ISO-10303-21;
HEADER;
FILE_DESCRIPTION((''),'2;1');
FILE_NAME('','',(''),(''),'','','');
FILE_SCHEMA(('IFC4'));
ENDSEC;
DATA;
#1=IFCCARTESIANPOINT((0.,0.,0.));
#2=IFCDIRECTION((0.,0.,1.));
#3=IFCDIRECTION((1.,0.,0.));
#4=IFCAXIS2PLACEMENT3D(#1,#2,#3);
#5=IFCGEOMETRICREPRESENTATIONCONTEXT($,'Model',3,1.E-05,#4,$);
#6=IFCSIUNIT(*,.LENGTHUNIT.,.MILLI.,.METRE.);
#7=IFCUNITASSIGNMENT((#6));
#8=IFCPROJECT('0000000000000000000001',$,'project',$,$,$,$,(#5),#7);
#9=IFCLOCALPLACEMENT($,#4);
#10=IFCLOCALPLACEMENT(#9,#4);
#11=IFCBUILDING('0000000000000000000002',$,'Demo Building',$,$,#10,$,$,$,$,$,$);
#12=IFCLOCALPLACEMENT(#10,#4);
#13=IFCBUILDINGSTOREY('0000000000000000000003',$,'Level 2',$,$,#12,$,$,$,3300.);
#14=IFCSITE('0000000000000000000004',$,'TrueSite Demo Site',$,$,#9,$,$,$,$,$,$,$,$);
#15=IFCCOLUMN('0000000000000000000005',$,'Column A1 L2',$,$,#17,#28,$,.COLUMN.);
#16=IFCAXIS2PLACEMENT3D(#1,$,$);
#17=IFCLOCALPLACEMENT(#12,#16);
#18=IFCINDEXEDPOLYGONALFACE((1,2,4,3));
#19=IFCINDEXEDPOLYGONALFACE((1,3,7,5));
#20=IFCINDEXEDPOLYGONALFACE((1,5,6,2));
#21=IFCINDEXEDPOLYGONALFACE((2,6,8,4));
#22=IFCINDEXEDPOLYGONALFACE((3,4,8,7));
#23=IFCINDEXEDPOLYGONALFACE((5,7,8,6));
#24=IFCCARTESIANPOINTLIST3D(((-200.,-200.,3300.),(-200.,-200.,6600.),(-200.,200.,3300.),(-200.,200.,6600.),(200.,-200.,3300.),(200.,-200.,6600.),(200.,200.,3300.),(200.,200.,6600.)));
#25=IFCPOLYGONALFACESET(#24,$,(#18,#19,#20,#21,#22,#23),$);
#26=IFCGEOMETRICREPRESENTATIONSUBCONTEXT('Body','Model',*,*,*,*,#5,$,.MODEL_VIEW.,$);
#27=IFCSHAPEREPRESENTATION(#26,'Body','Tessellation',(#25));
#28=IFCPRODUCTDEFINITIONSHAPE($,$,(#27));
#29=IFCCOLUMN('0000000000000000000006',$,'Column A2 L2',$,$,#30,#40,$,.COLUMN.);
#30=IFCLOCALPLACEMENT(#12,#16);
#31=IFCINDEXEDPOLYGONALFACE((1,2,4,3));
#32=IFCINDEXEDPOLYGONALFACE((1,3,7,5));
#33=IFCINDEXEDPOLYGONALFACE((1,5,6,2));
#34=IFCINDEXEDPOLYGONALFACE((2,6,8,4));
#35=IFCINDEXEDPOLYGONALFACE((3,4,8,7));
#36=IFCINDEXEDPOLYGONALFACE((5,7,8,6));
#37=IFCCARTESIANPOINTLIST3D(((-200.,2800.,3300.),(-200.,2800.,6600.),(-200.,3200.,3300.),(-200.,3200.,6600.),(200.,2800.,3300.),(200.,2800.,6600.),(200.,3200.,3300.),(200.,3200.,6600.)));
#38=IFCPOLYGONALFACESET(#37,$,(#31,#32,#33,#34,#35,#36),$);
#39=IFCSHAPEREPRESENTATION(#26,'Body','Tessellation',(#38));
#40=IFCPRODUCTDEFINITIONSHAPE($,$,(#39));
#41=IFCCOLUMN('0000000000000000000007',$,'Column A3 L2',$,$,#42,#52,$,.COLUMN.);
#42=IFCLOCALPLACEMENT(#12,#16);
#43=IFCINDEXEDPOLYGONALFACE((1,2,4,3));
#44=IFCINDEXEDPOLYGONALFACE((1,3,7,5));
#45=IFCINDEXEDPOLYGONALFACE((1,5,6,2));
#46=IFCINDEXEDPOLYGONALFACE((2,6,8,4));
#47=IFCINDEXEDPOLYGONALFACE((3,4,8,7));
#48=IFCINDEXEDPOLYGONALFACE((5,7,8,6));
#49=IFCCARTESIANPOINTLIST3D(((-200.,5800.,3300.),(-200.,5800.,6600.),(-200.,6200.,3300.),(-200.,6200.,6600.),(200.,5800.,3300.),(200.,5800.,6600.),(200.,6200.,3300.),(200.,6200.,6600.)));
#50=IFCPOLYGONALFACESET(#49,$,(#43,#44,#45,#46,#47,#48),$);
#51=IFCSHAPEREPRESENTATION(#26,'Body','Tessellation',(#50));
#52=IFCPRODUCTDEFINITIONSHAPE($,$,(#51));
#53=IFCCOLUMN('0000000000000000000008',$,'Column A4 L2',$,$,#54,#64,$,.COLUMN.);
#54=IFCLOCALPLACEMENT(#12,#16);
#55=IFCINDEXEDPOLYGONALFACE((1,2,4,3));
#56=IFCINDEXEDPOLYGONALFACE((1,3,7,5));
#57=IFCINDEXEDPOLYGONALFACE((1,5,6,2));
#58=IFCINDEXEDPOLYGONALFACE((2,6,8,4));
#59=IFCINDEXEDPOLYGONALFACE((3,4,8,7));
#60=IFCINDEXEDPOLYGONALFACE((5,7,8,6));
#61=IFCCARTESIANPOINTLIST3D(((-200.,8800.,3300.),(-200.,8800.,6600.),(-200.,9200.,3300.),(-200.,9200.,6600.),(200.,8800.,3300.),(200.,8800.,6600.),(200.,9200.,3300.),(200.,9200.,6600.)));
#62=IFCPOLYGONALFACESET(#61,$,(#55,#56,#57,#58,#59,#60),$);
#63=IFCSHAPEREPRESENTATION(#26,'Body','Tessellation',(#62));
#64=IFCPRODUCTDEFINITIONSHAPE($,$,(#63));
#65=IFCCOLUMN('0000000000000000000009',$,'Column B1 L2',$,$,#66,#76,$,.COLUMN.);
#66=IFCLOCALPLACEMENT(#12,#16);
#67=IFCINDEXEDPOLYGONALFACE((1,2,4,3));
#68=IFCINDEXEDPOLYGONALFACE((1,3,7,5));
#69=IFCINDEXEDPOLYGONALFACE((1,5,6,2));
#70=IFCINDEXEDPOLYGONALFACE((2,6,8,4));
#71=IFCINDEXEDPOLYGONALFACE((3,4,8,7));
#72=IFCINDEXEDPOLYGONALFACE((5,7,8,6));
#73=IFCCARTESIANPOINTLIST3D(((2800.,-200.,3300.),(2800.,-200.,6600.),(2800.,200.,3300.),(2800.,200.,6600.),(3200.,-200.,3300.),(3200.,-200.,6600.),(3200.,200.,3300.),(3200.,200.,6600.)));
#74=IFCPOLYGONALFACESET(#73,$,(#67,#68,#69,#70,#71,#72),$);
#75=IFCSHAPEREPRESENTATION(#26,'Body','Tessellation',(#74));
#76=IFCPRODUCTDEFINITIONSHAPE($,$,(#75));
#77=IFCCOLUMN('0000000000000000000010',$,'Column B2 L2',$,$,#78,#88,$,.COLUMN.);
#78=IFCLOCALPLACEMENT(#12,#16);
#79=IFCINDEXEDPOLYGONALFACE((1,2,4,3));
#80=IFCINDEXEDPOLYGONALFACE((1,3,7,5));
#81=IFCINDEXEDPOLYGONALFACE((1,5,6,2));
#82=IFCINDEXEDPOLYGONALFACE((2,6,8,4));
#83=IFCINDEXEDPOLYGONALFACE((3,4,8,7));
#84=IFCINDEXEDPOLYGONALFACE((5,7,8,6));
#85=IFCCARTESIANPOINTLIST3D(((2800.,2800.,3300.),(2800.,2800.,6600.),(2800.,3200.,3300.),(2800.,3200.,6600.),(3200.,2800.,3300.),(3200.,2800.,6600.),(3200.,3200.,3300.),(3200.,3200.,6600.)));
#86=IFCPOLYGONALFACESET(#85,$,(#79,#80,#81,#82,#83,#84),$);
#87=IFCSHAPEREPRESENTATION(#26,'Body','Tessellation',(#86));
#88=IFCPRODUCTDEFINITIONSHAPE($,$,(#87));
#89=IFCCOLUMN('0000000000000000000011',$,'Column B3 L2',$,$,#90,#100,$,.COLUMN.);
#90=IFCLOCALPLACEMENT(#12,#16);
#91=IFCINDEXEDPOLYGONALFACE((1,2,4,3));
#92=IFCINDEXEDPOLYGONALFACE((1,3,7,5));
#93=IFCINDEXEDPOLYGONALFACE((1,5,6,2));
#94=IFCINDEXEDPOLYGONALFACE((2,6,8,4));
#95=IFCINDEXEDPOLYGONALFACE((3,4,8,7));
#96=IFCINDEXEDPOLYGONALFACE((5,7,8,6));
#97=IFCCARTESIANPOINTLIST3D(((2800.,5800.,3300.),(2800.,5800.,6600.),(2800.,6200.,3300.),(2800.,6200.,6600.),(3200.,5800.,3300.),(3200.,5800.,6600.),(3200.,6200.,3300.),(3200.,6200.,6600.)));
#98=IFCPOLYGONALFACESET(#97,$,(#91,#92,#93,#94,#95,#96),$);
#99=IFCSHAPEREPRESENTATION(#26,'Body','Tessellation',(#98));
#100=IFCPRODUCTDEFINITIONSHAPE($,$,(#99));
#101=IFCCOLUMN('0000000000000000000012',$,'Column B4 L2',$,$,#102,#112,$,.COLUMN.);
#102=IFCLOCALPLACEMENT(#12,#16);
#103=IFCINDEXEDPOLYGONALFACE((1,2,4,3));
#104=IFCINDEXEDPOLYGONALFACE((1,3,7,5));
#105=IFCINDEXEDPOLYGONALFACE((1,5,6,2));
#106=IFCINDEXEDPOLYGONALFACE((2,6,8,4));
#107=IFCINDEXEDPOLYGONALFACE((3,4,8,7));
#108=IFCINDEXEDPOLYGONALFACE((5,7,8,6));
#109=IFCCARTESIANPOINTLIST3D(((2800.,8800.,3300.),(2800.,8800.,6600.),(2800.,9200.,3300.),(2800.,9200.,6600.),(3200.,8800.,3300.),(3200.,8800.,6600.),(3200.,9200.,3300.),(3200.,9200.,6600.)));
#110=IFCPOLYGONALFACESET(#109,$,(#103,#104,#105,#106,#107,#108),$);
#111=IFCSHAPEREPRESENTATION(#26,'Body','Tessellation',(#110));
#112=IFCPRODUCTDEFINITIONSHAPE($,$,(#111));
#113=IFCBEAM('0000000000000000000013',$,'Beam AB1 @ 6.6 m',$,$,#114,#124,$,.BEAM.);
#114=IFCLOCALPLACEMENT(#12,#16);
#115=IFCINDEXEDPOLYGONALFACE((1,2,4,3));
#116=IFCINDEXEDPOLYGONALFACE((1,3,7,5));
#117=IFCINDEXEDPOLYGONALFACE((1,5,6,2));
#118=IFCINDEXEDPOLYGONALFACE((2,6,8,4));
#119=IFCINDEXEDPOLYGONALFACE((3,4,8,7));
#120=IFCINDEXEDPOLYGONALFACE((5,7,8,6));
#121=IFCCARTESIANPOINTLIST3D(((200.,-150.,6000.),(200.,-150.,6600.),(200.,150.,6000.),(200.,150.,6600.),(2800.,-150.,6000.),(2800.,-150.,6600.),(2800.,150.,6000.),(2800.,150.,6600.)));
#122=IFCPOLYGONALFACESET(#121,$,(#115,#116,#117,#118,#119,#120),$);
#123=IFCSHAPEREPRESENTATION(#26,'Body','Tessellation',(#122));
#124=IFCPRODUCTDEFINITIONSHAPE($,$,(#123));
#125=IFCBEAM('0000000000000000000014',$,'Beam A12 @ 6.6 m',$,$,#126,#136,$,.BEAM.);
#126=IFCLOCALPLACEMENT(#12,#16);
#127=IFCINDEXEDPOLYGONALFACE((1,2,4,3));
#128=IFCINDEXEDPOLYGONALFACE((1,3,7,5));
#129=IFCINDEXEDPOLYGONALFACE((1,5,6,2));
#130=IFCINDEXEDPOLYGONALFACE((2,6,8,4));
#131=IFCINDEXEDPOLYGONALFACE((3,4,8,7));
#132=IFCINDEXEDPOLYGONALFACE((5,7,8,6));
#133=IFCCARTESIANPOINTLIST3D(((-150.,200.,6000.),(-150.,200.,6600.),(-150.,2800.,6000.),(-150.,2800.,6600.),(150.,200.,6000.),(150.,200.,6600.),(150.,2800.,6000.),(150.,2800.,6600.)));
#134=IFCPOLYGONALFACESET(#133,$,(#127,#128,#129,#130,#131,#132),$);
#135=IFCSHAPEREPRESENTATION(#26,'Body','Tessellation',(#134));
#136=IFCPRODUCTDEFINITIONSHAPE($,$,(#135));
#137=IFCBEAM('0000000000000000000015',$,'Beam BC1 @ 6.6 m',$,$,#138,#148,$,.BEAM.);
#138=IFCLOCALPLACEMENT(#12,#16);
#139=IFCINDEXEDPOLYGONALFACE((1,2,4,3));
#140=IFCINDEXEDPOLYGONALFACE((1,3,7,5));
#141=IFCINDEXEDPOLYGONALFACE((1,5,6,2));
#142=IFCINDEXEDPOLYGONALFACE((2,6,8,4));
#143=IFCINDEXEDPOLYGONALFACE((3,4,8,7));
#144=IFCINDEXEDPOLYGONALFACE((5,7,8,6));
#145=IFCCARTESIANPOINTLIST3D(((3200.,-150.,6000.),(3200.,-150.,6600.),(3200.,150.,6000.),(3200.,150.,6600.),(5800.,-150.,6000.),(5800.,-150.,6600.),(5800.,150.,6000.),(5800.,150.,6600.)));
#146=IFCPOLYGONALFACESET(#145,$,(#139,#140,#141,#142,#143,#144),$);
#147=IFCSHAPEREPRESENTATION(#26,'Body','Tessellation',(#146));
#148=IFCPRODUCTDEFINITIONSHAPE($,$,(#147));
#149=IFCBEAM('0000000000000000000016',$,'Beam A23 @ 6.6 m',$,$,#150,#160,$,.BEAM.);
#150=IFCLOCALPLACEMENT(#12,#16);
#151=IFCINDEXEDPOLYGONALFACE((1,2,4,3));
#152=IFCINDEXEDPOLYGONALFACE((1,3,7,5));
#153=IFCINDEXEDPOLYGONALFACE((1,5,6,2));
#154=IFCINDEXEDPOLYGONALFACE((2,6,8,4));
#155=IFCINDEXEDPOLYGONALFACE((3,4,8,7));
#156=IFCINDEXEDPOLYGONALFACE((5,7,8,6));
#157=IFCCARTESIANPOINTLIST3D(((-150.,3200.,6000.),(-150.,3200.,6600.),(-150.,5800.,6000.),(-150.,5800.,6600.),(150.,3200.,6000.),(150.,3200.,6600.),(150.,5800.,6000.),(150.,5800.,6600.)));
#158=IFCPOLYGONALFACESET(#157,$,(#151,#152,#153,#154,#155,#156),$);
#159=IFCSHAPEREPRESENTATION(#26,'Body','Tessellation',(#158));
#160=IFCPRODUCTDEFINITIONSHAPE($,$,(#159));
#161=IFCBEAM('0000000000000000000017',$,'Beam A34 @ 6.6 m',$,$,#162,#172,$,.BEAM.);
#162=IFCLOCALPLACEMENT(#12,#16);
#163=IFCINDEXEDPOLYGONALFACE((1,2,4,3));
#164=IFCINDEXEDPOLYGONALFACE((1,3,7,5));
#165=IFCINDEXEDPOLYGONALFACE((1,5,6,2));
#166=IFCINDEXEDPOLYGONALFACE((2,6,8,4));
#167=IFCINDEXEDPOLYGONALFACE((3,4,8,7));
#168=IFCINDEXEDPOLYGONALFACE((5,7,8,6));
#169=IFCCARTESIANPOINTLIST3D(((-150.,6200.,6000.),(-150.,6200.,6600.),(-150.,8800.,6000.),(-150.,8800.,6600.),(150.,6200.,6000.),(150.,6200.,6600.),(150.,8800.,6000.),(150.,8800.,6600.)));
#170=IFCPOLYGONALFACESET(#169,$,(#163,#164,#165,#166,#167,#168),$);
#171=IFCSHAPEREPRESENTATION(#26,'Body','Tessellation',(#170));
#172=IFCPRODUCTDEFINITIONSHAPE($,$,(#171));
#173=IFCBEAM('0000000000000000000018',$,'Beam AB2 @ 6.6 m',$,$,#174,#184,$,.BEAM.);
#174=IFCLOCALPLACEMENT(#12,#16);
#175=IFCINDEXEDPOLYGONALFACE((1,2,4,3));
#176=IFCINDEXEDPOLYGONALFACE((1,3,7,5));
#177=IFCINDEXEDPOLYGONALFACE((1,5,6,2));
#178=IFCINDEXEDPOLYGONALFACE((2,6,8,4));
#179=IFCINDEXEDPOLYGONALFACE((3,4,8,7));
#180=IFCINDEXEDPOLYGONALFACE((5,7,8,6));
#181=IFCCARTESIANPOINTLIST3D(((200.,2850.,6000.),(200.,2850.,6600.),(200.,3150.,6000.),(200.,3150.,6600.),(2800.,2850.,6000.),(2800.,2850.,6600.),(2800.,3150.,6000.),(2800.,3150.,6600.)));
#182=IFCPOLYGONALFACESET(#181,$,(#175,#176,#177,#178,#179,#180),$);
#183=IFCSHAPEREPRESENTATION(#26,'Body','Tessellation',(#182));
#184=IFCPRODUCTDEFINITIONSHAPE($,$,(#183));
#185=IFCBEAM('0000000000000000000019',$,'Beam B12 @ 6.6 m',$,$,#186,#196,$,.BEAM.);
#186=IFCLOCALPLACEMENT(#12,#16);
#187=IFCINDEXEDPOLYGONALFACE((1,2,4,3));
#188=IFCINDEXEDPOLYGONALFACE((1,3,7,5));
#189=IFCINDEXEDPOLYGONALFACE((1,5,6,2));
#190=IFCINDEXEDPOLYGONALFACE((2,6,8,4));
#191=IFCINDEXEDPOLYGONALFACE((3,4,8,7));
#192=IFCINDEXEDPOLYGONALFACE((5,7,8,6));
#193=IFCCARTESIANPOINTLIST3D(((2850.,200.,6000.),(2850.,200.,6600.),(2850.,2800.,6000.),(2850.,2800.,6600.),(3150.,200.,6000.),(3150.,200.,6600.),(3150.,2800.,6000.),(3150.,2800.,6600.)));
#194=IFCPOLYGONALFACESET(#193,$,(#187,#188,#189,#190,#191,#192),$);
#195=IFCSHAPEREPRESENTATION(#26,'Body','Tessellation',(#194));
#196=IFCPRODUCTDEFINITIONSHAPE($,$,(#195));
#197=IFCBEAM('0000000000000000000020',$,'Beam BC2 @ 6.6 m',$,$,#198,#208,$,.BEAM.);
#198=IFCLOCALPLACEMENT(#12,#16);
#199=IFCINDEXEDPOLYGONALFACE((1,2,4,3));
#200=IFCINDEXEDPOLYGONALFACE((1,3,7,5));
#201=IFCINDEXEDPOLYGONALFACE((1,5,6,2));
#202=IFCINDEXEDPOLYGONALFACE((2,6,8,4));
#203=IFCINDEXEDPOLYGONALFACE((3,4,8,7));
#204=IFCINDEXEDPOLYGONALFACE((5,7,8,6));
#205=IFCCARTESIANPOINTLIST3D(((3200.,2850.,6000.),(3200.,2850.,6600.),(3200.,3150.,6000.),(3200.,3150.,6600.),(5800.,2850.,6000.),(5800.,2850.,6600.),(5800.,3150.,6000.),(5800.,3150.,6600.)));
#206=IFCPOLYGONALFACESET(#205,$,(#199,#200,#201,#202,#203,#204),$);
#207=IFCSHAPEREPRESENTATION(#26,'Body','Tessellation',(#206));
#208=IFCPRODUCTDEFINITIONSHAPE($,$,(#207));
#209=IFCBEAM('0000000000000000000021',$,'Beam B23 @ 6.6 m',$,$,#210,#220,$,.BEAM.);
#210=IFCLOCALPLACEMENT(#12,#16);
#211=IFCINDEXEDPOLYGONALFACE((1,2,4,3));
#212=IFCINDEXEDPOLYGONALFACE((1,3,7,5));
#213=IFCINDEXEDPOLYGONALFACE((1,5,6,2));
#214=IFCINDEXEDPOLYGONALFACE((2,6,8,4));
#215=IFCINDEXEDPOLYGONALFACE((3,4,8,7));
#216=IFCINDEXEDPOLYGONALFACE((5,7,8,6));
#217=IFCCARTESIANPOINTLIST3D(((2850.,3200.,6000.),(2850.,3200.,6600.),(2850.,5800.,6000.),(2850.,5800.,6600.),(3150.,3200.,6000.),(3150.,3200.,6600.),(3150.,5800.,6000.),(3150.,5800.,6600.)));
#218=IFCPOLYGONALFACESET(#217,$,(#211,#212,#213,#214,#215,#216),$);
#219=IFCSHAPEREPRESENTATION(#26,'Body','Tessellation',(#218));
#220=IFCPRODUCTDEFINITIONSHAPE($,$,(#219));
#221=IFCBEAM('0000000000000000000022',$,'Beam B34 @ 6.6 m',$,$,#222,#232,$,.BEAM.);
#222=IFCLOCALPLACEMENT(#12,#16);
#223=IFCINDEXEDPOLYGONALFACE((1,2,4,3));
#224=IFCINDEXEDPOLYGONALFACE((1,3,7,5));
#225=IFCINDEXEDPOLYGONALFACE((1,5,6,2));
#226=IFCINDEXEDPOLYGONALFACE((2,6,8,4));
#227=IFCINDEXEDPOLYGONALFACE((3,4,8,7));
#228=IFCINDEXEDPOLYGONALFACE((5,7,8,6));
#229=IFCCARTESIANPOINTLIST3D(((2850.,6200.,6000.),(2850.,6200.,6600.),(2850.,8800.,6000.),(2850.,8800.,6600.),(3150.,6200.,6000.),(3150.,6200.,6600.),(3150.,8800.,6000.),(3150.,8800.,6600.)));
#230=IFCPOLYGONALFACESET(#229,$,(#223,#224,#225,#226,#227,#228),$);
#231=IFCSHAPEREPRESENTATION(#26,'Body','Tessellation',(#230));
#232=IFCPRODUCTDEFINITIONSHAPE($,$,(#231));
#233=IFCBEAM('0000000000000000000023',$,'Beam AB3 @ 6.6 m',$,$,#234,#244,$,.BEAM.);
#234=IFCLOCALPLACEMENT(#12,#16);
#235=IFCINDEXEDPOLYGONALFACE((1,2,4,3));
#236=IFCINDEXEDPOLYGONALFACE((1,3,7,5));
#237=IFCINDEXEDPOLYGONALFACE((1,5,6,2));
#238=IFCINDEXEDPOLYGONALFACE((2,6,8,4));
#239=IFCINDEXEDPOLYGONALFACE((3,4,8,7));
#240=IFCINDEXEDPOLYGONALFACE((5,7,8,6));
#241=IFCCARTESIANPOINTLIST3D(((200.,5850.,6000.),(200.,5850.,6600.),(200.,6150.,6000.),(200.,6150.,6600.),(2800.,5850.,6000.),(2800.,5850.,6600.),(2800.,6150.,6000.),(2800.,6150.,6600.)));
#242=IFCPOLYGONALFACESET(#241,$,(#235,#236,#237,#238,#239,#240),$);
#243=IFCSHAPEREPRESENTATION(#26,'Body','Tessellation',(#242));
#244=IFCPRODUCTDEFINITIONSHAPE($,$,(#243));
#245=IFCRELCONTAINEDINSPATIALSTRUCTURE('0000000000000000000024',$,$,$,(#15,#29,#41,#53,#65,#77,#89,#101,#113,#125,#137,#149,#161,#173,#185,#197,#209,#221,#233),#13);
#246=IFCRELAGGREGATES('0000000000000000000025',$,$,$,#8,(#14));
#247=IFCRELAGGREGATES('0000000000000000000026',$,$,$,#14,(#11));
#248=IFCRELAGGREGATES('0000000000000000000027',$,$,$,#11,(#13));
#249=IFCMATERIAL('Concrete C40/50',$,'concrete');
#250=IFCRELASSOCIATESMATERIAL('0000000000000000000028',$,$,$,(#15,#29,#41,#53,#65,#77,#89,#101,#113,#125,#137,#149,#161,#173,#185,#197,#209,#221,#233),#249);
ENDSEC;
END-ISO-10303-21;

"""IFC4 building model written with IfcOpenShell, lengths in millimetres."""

from ifc_helpers import new_model, si_unit, frame, origin_with_axes, place, context, subcontext, project, spatial, rectangle, extrude, material, element, save


model = new_model("IFC4")

# Units and contexts
model_context = context("Model", 3, precision=1e-05, world=origin_with_axes())
body_context = subcontext(model_context, "Body", "Model", "MODEL_VIEW")
ifc_project = project(units=[si_unit("LENGTHUNIT", "METRE", prefix="MILLI")], contexts=[model_context])

# Site, building, storey
site_placement = place(None, origin_with_axes())
site = spatial("IfcSite", under=ifc_project, at=site_placement, Name="TrueSite Demo Site")
building_placement = place(site_placement, origin_with_axes())
building = spatial("IfcBuilding", under=site, at=building_placement, Name="Demo Building")
storey_placement = place(building_placement, origin_with_axes())
storey = spatial("IfcBuildingStorey", under=building, at=storey_placement, Name="Level 2", Elevation=3300.0)

# Columns
ifc_material_1 = material(Name="Concrete C40/50", Category="concrete")
for number, where, z_axis, x_axis, name in (
    (1, (0.0, 0.0, 3300.0), (0.0, 0.0, 1.0), (1.0, 0.0, 0.0), "Column A1 L2"),
    (2, (0.0, 3000.0, 3300.0), (0.0, 0.0, 1.0), (1.0, 0.0, 0.0), "Column A2 L2"),
    (3, (0.0, 6000.0, 3300.0), (0.0, 0.0, 1.0), (1.0, 0.0, 0.0), "Column A3 L2"),
    (4, (0.0, 9000.0, 3300.0), (0.0, 0.0, 1.0), (1.0, 0.0, 0.0), "Column A4 L2"),
    (5, (3000.0, 0.0, 3300.0), (0.0, 0.0, 1.0), (1.0, 0.0, 0.0), "Column B1 L2"),
    (6, (3000.0, 3000.0, 3300.0), (0.0, 0.0, 1.0), (1.0, 0.0, 0.0), "Column B2 L2"),
    (7, (3000.0, 6000.0, 3300.0), (0.0, 0.0, 1.0), (1.0, 0.0, 0.0), "Column B3 L2"),
    (8, (3000.0, 9000.0, 3300.0), (0.0, 0.0, 1.0), (1.0, 0.0, 0.0), "Column B4 L2"),
):
    element("IfcColumn", number, at=place(storey_placement, frame(where, z_axis=z_axis, x_axis=x_axis)), inside=storey, material=ifc_material_1, Name=name, PredefinedType="COLUMN", context=body_context, shape_type="SweptSolid", body=[
        extrude(rectangle(XDim=400.0, YDim=400.0), origin_with_axes(), (0.0, 0.0, 1.0), 3300.0),
    ])

# Beams
for number, where, z_axis, x_axis, name in (
    (9, (200.0, 0.0, 6300.0), (1.0, 0.0, 0.0), (0.0, 1.0, 0.0), "Beam AB1 @ 6.6 m"),
    (10, (0.0, 200.0, 6300.0), (0.0, 1.0, 0.0), (1.0, 0.0, 0.0), "Beam A12 @ 6.6 m"),
    (11, (3200.0, 0.0, 6300.0), (1.0, 0.0, 0.0), (0.0, 1.0, 0.0), "Beam BC1 @ 6.6 m"),
    (12, (0.0, 3200.0, 6300.0), (0.0, 1.0, 0.0), (1.0, 0.0, 0.0), "Beam A23 @ 6.6 m"),
):
    element("IfcBeam", number, at=place(storey_placement, frame(where, z_axis=z_axis, x_axis=x_axis)), inside=storey, material=ifc_material_1, Name=name, PredefinedType="BEAM", context=body_context, shape_type="SweptSolid", body=[
        extrude(rectangle(XDim=300.0, YDim=600.0), origin_with_axes(), (0.0, 0.0, 1.0), 2600.0),
    ])
beam_1_placement = place(storey_placement, frame((0.0, 6200.0, 6300.0), z_axis=(0.0, 1.0, 0.0), x_axis=(1.0, 0.0, 0.0)))
element("IfcBeam", 13, at=beam_1_placement, inside=storey, material=ifc_material_1, Name="Beam A34 @ 6.6 m", PredefinedType="BEAM", context=body_context, shape_type="SweptSolid", body=[
    extrude(rectangle(XDim=300.0, YDim=600.0), origin_with_axes(), (0.0, 0.0, 1.0), 2600.0),
])
for number, where, z_axis, x_axis, name in (
    (14, (200.0, 3000.0, 6300.0), (1.0, 0.0, 0.0), (0.0, 1.0, 0.0), "Beam AB2 @ 6.6 m"),
    (15, (3000.0, 200.0, 6300.0), (0.0, 1.0, 0.0), (1.0, 0.0, 0.0), "Beam B12 @ 6.6 m"),
    (16, (3200.0, 3000.0, 6300.0), (1.0, 0.0, 0.0), (0.0, 1.0, 0.0), "Beam BC2 @ 6.6 m"),
    (17, (3000.0, 3200.0, 6300.0), (0.0, 1.0, 0.0), (1.0, 0.0, 0.0), "Beam B23 @ 6.6 m"),
):
    element("IfcBeam", number, at=place(storey_placement, frame(where, z_axis=z_axis, x_axis=x_axis)), inside=storey, material=ifc_material_1, Name=name, PredefinedType="BEAM", context=body_context, shape_type="SweptSolid", body=[
        extrude(rectangle(XDim=300.0, YDim=600.0), origin_with_axes(), (0.0, 0.0, 1.0), 2600.0),
    ])
beam_2_placement = place(storey_placement, frame((3000.0, 6200.0, 6300.0), z_axis=(0.0, 1.0, 0.0), x_axis=(1.0, 0.0, 0.0)))
element("IfcBeam", 18, at=beam_2_placement, inside=storey, material=ifc_material_1, Name="Beam B34 @ 6.6 m", PredefinedType="BEAM", context=body_context, shape_type="SweptSolid", body=[
    extrude(rectangle(XDim=300.0, YDim=600.0), origin_with_axes(), (0.0, 0.0, 1.0), 2600.0),
])
for number, where, z_axis, x_axis, name in (
    (19, (200.0, 6000.0, 6300.0), (1.0, 0.0, 0.0), (0.0, 1.0, 0.0), "Beam AB3 @ 6.6 m"),
):
    element("IfcBeam", number, at=place(storey_placement, frame(where, z_axis=z_axis, x_axis=x_axis)), inside=storey, material=ifc_material_1, Name=name, PredefinedType="BEAM", context=body_context, shape_type="SweptSolid", body=[
        extrude(rectangle(XDim=300.0, YDim=600.0), origin_with_axes(), (0.0, 0.0, 1.0), 2600.0),
    ])

save(model, "model.ifc")
